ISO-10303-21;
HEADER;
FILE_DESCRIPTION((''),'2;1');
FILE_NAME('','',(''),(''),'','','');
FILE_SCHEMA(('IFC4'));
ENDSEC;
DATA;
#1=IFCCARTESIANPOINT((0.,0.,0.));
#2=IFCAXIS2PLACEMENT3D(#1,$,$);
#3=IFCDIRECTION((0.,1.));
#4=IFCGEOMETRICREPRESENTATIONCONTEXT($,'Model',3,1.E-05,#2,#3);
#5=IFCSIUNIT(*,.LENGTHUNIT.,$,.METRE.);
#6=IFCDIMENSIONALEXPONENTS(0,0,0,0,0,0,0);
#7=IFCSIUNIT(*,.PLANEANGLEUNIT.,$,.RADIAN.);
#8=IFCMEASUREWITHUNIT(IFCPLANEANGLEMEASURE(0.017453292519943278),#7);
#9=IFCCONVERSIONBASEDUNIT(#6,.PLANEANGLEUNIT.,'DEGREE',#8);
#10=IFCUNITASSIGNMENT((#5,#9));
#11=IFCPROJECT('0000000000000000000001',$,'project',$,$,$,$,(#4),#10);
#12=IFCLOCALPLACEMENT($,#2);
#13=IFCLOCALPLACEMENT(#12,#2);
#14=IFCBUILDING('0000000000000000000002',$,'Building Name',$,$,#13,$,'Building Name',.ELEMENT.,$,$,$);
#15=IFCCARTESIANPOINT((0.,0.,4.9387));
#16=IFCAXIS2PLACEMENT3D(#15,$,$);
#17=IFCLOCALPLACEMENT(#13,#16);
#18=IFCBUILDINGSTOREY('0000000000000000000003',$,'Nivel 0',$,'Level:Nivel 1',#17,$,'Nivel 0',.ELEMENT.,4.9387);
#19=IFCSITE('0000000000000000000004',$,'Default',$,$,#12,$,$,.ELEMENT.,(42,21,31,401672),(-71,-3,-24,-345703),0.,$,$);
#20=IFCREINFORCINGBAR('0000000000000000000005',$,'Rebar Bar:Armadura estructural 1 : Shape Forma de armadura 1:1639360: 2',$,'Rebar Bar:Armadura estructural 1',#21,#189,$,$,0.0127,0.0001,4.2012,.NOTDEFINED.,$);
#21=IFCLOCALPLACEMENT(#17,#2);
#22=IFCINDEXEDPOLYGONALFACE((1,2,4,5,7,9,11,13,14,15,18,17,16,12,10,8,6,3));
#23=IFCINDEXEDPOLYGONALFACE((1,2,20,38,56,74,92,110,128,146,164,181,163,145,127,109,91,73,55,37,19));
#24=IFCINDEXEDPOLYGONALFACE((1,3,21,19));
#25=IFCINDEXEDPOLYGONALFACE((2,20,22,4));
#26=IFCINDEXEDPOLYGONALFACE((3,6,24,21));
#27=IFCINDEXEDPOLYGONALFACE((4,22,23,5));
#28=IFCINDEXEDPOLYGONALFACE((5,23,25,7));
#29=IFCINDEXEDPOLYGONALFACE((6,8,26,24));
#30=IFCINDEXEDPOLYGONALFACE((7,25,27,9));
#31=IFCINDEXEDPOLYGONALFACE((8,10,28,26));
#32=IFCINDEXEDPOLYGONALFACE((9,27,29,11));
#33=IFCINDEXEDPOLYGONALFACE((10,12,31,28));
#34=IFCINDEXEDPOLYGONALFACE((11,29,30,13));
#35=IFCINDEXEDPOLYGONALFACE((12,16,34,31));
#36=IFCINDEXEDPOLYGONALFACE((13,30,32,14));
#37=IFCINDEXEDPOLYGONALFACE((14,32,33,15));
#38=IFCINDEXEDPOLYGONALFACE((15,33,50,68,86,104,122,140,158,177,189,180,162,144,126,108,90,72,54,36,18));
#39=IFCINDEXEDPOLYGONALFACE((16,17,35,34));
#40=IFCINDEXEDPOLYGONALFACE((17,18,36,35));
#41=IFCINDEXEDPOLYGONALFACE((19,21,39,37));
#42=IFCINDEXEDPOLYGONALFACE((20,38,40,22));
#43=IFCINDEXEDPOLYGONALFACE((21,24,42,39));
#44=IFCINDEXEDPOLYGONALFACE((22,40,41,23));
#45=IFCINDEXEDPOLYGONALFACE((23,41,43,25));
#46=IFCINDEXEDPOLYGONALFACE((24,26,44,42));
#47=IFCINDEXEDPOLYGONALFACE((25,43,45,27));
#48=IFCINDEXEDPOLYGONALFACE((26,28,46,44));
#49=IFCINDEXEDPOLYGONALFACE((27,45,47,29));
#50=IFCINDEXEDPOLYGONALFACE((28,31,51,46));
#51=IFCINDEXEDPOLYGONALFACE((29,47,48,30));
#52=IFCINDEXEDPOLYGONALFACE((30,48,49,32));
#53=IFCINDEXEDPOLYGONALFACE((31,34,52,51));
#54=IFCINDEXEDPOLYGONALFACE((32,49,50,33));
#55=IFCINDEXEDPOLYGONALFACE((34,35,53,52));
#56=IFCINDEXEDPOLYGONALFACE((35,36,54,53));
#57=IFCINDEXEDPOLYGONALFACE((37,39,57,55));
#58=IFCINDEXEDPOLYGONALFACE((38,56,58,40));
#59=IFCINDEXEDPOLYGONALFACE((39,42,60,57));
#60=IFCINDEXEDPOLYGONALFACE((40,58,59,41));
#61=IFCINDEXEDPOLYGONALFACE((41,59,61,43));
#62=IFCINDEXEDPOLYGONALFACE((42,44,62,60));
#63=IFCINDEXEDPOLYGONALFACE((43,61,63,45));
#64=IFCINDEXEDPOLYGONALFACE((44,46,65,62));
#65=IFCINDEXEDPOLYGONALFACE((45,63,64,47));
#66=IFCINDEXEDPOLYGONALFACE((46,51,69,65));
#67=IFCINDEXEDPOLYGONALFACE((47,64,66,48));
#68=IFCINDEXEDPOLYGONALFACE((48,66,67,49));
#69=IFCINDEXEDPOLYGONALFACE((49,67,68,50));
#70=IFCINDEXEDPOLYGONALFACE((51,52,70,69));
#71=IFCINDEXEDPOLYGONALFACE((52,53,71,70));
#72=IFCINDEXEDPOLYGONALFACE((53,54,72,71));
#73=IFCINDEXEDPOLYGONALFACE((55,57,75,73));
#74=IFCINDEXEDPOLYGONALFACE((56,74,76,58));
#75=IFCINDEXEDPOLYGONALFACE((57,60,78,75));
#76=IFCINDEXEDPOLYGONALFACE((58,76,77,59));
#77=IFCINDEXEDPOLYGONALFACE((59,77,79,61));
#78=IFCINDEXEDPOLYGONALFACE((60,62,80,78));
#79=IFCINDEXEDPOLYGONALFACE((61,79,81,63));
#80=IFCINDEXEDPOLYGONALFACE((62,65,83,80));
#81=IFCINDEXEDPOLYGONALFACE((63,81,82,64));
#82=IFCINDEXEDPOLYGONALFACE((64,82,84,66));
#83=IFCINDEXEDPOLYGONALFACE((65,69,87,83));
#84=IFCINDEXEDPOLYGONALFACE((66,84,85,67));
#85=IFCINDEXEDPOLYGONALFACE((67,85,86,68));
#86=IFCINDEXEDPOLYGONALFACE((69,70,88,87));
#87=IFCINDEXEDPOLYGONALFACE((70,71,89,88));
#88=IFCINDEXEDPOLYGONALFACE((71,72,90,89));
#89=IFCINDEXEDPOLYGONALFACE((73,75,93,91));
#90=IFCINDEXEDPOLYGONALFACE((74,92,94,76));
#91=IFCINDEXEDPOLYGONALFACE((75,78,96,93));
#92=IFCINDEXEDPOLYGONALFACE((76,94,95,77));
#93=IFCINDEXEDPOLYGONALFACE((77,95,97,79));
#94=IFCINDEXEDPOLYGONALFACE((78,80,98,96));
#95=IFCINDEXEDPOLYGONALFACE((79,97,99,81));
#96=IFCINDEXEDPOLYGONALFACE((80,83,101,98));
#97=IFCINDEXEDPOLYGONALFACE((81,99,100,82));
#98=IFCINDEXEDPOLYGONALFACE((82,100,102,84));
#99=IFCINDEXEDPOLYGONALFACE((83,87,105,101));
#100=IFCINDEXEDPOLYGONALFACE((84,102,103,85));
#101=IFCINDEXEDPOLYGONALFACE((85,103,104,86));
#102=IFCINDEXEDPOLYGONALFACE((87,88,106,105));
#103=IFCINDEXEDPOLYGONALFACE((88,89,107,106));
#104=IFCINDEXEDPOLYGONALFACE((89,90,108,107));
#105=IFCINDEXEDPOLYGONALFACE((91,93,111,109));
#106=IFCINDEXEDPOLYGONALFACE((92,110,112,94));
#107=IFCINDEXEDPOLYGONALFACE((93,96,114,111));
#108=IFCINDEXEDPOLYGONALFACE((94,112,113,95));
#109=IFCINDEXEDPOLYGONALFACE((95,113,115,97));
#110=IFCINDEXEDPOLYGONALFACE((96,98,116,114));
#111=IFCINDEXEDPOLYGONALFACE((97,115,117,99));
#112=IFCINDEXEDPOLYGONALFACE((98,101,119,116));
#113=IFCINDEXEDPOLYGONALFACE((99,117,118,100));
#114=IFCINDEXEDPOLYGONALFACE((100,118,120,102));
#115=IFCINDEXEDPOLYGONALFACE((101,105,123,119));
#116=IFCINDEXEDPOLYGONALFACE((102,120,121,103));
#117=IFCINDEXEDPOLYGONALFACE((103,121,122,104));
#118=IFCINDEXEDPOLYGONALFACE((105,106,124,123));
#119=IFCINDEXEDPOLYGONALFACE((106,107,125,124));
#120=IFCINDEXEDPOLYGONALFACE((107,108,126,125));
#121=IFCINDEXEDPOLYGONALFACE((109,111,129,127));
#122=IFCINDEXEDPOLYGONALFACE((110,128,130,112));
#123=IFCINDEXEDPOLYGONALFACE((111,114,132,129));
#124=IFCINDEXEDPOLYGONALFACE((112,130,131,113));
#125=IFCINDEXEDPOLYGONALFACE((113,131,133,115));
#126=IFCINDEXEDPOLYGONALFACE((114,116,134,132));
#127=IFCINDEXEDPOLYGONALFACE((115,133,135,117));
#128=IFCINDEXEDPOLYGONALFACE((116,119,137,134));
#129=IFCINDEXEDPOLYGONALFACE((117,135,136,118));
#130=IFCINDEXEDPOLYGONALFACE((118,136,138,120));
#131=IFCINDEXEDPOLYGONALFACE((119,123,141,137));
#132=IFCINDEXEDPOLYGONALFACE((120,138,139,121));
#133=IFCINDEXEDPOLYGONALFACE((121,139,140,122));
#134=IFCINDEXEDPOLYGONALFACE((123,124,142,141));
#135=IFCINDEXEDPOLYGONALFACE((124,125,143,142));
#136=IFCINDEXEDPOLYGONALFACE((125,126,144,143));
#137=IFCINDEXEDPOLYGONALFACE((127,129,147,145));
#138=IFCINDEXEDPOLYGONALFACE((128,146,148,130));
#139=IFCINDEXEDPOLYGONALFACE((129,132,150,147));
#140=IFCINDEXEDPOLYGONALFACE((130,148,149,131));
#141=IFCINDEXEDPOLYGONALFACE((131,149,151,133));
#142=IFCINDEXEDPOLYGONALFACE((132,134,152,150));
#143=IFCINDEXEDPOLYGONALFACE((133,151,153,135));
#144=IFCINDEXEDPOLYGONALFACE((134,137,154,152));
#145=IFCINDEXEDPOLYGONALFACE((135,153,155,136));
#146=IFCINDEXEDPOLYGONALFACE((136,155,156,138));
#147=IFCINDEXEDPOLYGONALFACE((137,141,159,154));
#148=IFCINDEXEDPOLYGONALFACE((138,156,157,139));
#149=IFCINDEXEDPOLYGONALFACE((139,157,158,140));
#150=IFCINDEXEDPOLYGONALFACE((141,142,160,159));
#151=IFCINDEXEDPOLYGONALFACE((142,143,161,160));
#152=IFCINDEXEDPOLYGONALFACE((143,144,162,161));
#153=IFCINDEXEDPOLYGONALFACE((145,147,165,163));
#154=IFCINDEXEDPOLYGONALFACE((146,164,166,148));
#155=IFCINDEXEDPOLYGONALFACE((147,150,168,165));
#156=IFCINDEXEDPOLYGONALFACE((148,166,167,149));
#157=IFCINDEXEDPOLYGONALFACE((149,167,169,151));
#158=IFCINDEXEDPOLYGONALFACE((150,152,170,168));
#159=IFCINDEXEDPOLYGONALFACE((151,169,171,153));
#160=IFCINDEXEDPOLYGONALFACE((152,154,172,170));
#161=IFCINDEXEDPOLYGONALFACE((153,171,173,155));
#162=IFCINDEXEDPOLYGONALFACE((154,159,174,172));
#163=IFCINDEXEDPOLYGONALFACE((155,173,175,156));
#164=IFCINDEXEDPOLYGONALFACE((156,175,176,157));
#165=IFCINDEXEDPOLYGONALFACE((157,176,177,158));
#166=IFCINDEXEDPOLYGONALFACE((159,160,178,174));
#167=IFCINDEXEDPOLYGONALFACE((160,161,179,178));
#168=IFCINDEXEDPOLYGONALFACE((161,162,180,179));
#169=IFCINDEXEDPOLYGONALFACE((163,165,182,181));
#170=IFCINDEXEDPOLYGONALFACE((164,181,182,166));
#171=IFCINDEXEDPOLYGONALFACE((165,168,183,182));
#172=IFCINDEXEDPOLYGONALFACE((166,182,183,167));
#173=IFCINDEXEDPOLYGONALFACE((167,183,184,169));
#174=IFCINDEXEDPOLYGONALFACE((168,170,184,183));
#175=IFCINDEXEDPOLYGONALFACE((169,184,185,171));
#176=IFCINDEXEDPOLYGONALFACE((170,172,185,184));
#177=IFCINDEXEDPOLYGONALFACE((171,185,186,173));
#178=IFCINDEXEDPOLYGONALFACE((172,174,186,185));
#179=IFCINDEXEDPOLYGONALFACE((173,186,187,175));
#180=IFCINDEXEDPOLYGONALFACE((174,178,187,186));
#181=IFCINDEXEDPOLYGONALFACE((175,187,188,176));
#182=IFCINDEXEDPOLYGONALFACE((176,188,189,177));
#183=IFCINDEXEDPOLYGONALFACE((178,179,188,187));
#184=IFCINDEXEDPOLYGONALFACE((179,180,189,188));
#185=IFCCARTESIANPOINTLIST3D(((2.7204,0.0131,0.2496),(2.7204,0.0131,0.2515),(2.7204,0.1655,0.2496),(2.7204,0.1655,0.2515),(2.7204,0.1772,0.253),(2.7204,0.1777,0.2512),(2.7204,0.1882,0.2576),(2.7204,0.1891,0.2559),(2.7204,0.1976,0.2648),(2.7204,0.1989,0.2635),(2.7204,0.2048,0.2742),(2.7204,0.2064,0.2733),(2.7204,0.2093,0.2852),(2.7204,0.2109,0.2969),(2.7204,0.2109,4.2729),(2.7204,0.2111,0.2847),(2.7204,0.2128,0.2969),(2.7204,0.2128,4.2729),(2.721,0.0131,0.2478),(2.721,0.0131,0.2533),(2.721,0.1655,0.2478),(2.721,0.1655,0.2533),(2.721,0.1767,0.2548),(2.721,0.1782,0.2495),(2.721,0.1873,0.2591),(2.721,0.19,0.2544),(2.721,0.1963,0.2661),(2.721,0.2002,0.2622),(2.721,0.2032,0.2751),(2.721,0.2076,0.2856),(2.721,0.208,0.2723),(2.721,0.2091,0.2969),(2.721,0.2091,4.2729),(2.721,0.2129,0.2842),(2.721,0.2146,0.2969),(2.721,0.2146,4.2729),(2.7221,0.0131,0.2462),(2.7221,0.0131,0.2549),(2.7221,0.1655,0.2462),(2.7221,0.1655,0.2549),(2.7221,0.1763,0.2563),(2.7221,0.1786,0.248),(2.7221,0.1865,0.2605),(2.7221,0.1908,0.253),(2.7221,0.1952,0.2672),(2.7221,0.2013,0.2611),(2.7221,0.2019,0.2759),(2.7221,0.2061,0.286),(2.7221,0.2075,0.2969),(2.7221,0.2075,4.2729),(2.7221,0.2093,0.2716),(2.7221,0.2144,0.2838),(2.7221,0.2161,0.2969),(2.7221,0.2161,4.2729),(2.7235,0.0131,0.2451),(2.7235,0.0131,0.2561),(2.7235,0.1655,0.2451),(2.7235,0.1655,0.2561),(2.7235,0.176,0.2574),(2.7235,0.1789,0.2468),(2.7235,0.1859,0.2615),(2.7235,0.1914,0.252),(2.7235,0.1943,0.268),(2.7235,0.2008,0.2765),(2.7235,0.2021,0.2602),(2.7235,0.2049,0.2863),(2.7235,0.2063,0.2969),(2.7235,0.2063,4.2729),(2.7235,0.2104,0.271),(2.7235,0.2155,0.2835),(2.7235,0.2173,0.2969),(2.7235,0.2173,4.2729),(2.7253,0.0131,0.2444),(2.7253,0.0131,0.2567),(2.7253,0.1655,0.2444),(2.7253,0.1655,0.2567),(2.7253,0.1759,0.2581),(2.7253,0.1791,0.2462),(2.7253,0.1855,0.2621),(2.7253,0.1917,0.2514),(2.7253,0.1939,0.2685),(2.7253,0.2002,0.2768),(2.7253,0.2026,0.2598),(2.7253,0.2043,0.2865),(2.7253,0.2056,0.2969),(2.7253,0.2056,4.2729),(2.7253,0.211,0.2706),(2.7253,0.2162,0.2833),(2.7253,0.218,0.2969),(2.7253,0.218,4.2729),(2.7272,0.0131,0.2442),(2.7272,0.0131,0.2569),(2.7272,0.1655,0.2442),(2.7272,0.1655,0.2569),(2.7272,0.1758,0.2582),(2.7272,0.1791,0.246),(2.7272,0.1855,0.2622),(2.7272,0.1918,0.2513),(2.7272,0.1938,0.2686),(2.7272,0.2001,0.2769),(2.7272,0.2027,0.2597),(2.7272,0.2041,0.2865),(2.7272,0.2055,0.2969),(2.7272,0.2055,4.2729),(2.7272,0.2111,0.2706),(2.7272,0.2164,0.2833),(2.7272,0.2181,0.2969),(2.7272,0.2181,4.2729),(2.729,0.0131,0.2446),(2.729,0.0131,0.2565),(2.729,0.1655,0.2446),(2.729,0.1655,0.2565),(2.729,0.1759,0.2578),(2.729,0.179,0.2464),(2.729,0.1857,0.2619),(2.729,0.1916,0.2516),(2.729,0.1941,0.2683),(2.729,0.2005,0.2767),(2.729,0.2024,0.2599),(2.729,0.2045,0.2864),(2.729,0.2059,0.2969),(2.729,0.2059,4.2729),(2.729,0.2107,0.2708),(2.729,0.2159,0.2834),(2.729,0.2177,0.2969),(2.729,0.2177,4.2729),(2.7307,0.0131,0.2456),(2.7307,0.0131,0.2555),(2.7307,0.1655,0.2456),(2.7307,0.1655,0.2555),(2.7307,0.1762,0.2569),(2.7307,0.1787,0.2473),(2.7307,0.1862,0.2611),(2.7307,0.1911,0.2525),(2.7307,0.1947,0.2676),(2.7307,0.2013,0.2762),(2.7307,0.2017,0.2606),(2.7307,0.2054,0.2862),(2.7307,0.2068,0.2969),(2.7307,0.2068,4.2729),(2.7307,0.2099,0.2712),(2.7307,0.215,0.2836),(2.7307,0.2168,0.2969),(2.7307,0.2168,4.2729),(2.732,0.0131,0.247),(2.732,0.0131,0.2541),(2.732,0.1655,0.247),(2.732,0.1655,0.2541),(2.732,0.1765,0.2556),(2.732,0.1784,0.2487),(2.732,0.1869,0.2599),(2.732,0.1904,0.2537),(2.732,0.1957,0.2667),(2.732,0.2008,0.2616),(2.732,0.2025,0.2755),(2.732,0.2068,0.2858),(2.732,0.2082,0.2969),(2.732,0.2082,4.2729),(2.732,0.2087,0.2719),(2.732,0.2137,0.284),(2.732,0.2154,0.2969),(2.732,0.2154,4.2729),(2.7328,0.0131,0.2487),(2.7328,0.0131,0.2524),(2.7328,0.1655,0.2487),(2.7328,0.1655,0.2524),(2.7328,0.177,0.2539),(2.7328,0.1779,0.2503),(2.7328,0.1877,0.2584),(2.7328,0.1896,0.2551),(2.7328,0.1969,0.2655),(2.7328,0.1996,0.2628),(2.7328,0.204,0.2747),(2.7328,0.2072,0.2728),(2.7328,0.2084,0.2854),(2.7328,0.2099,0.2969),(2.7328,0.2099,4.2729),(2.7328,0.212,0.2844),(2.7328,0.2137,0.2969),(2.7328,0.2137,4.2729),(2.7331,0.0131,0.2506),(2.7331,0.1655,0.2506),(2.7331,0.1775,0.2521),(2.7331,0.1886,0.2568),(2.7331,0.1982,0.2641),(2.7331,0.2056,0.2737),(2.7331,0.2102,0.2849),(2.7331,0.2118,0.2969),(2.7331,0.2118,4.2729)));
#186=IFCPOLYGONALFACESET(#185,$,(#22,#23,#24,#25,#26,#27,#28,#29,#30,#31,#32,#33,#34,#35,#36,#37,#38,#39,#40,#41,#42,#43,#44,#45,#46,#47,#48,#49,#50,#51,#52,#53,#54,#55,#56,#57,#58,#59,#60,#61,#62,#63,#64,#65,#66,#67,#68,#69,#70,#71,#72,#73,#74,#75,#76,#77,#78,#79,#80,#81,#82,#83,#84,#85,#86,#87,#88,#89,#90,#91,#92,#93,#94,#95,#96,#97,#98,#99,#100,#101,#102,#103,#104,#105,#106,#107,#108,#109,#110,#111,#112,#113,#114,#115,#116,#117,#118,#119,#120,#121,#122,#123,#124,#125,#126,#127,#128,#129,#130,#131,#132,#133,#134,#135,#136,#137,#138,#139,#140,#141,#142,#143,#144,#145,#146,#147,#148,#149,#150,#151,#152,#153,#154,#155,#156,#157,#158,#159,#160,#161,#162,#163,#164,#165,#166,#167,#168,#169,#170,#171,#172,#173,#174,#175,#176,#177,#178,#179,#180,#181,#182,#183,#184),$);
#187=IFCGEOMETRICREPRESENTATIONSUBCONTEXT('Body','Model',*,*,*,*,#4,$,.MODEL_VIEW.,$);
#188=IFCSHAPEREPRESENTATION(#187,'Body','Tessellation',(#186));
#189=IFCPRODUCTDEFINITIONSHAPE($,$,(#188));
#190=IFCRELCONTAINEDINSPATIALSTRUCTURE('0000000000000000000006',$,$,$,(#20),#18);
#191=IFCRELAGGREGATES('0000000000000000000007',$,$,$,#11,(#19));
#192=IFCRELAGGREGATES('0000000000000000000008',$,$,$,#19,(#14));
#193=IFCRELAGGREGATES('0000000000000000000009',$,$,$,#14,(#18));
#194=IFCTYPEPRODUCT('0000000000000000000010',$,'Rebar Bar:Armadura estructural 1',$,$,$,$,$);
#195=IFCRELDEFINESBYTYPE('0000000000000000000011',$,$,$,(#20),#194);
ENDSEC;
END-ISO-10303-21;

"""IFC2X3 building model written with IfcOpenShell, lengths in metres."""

from ifc_helpers import new_model, entity, si_unit, converted_unit, direction, frame, origin, place, context, subcontext, project, spatial, type_object, element, save


model = new_model("IFC2X3")

# Units and contexts
model_context = context("Model", 3, precision=1e-05, world=origin(), true_north=direction((0.0, 1.0)))
body_context = subcontext(model_context, "Body", "Model", "MODEL_VIEW")
ifc_project = project(units=[si_unit("LENGTHUNIT", "METRE"), converted_unit("PLANEANGLEUNIT", "DEGREE", entity("IfcPlaneAngleMeasure", 0.017453292519943278), si_unit("PLANEANGLEUNIT", "RADIAN"), dimensions=[0, 0, 0, 0, 0, 0, 0])], contexts=[model_context])

# Site, building, storey
site_placement = place(None, origin())
site = spatial("IfcSite", under=ifc_project, at=site_placement, Name="Default", CompositionType="ELEMENT", RefLatitude=(42, 21, 31, 401672), RefLongitude=(-71, -3, -24, -345703), RefElevation=0.0)
building_placement = place(site_placement, origin())
building = spatial("IfcBuilding", under=site, at=building_placement, Name="Building Name", LongName="Building Name", CompositionType="ELEMENT")
storey_placement = place(building_placement, frame((0.0, 0.0, 4.9387)))
storey = spatial("IfcBuildingStorey", under=building, at=storey_placement, Name="Nivel 0", ObjectType="Level:Nivel 1", LongName="Nivel 0", CompositionType="ELEMENT", Elevation=4.9387)

# Reinforcing bar
type_product = type_object("IfcTypeProduct", Name="Rebar Bar:Armadura estructural 1")
reinforcing_bar_1_placement = place(storey_placement, origin())
element("IfcReinforcingBar", 1, at=reinforcing_bar_1_placement, inside=storey, type_object=type_product, Name="Rebar Bar:Armadura estructural 1 : Shape Forma de armadura 1:1639360: 2", ObjectType="Rebar Bar:Armadura estructural 1", BarLength=4.2012, BarRole="NOTDEFINED", CrossSectionArea=0.0001, NominalDiameter=0.0127, context=body_context, shape_type="AdvancedSweptSolid", body=[
    entity("IfcSweptDiskSolid", entity("IfcCompositeCurve", [entity("IfcCompositeCurveSegment", "CONTINUOUS", True, entity("IfcPolyline", [entity("IfcCartesianPoint", [2.7267, 0.0131, 0.2506]), entity("IfcCartesianPoint", [2.7267, 0.1655, 0.2506])])), entity("IfcCompositeCurveSegment", "CONTINUOUS", True, entity("IfcTrimmedCurve", entity("IfcCircle", entity("IfcAxis2Placement3D", entity("IfcCartesianPoint", [2.7267, 0.1655, 0.2969]), entity("IfcDirection", [1.0, 0.0, 0.0]), entity("IfcDirection", [0.0, 1.0, 0.0])), 0.0464), [entity("IfcParameterValue", 270.0)], [entity("IfcParameterValue", 360.0)], True, "PARAMETER")), entity("IfcCompositeCurveSegment", "CONTINUOUS", True, entity("IfcPolyline", [entity("IfcCartesianPoint", [2.7267, 0.2118, 0.2969]), entity("IfcCartesianPoint", [2.7267, 0.2118, 4.2729])]))], False), 0.0063, None, 0.0, 92.0),
])

save(model, "model.ifc")
